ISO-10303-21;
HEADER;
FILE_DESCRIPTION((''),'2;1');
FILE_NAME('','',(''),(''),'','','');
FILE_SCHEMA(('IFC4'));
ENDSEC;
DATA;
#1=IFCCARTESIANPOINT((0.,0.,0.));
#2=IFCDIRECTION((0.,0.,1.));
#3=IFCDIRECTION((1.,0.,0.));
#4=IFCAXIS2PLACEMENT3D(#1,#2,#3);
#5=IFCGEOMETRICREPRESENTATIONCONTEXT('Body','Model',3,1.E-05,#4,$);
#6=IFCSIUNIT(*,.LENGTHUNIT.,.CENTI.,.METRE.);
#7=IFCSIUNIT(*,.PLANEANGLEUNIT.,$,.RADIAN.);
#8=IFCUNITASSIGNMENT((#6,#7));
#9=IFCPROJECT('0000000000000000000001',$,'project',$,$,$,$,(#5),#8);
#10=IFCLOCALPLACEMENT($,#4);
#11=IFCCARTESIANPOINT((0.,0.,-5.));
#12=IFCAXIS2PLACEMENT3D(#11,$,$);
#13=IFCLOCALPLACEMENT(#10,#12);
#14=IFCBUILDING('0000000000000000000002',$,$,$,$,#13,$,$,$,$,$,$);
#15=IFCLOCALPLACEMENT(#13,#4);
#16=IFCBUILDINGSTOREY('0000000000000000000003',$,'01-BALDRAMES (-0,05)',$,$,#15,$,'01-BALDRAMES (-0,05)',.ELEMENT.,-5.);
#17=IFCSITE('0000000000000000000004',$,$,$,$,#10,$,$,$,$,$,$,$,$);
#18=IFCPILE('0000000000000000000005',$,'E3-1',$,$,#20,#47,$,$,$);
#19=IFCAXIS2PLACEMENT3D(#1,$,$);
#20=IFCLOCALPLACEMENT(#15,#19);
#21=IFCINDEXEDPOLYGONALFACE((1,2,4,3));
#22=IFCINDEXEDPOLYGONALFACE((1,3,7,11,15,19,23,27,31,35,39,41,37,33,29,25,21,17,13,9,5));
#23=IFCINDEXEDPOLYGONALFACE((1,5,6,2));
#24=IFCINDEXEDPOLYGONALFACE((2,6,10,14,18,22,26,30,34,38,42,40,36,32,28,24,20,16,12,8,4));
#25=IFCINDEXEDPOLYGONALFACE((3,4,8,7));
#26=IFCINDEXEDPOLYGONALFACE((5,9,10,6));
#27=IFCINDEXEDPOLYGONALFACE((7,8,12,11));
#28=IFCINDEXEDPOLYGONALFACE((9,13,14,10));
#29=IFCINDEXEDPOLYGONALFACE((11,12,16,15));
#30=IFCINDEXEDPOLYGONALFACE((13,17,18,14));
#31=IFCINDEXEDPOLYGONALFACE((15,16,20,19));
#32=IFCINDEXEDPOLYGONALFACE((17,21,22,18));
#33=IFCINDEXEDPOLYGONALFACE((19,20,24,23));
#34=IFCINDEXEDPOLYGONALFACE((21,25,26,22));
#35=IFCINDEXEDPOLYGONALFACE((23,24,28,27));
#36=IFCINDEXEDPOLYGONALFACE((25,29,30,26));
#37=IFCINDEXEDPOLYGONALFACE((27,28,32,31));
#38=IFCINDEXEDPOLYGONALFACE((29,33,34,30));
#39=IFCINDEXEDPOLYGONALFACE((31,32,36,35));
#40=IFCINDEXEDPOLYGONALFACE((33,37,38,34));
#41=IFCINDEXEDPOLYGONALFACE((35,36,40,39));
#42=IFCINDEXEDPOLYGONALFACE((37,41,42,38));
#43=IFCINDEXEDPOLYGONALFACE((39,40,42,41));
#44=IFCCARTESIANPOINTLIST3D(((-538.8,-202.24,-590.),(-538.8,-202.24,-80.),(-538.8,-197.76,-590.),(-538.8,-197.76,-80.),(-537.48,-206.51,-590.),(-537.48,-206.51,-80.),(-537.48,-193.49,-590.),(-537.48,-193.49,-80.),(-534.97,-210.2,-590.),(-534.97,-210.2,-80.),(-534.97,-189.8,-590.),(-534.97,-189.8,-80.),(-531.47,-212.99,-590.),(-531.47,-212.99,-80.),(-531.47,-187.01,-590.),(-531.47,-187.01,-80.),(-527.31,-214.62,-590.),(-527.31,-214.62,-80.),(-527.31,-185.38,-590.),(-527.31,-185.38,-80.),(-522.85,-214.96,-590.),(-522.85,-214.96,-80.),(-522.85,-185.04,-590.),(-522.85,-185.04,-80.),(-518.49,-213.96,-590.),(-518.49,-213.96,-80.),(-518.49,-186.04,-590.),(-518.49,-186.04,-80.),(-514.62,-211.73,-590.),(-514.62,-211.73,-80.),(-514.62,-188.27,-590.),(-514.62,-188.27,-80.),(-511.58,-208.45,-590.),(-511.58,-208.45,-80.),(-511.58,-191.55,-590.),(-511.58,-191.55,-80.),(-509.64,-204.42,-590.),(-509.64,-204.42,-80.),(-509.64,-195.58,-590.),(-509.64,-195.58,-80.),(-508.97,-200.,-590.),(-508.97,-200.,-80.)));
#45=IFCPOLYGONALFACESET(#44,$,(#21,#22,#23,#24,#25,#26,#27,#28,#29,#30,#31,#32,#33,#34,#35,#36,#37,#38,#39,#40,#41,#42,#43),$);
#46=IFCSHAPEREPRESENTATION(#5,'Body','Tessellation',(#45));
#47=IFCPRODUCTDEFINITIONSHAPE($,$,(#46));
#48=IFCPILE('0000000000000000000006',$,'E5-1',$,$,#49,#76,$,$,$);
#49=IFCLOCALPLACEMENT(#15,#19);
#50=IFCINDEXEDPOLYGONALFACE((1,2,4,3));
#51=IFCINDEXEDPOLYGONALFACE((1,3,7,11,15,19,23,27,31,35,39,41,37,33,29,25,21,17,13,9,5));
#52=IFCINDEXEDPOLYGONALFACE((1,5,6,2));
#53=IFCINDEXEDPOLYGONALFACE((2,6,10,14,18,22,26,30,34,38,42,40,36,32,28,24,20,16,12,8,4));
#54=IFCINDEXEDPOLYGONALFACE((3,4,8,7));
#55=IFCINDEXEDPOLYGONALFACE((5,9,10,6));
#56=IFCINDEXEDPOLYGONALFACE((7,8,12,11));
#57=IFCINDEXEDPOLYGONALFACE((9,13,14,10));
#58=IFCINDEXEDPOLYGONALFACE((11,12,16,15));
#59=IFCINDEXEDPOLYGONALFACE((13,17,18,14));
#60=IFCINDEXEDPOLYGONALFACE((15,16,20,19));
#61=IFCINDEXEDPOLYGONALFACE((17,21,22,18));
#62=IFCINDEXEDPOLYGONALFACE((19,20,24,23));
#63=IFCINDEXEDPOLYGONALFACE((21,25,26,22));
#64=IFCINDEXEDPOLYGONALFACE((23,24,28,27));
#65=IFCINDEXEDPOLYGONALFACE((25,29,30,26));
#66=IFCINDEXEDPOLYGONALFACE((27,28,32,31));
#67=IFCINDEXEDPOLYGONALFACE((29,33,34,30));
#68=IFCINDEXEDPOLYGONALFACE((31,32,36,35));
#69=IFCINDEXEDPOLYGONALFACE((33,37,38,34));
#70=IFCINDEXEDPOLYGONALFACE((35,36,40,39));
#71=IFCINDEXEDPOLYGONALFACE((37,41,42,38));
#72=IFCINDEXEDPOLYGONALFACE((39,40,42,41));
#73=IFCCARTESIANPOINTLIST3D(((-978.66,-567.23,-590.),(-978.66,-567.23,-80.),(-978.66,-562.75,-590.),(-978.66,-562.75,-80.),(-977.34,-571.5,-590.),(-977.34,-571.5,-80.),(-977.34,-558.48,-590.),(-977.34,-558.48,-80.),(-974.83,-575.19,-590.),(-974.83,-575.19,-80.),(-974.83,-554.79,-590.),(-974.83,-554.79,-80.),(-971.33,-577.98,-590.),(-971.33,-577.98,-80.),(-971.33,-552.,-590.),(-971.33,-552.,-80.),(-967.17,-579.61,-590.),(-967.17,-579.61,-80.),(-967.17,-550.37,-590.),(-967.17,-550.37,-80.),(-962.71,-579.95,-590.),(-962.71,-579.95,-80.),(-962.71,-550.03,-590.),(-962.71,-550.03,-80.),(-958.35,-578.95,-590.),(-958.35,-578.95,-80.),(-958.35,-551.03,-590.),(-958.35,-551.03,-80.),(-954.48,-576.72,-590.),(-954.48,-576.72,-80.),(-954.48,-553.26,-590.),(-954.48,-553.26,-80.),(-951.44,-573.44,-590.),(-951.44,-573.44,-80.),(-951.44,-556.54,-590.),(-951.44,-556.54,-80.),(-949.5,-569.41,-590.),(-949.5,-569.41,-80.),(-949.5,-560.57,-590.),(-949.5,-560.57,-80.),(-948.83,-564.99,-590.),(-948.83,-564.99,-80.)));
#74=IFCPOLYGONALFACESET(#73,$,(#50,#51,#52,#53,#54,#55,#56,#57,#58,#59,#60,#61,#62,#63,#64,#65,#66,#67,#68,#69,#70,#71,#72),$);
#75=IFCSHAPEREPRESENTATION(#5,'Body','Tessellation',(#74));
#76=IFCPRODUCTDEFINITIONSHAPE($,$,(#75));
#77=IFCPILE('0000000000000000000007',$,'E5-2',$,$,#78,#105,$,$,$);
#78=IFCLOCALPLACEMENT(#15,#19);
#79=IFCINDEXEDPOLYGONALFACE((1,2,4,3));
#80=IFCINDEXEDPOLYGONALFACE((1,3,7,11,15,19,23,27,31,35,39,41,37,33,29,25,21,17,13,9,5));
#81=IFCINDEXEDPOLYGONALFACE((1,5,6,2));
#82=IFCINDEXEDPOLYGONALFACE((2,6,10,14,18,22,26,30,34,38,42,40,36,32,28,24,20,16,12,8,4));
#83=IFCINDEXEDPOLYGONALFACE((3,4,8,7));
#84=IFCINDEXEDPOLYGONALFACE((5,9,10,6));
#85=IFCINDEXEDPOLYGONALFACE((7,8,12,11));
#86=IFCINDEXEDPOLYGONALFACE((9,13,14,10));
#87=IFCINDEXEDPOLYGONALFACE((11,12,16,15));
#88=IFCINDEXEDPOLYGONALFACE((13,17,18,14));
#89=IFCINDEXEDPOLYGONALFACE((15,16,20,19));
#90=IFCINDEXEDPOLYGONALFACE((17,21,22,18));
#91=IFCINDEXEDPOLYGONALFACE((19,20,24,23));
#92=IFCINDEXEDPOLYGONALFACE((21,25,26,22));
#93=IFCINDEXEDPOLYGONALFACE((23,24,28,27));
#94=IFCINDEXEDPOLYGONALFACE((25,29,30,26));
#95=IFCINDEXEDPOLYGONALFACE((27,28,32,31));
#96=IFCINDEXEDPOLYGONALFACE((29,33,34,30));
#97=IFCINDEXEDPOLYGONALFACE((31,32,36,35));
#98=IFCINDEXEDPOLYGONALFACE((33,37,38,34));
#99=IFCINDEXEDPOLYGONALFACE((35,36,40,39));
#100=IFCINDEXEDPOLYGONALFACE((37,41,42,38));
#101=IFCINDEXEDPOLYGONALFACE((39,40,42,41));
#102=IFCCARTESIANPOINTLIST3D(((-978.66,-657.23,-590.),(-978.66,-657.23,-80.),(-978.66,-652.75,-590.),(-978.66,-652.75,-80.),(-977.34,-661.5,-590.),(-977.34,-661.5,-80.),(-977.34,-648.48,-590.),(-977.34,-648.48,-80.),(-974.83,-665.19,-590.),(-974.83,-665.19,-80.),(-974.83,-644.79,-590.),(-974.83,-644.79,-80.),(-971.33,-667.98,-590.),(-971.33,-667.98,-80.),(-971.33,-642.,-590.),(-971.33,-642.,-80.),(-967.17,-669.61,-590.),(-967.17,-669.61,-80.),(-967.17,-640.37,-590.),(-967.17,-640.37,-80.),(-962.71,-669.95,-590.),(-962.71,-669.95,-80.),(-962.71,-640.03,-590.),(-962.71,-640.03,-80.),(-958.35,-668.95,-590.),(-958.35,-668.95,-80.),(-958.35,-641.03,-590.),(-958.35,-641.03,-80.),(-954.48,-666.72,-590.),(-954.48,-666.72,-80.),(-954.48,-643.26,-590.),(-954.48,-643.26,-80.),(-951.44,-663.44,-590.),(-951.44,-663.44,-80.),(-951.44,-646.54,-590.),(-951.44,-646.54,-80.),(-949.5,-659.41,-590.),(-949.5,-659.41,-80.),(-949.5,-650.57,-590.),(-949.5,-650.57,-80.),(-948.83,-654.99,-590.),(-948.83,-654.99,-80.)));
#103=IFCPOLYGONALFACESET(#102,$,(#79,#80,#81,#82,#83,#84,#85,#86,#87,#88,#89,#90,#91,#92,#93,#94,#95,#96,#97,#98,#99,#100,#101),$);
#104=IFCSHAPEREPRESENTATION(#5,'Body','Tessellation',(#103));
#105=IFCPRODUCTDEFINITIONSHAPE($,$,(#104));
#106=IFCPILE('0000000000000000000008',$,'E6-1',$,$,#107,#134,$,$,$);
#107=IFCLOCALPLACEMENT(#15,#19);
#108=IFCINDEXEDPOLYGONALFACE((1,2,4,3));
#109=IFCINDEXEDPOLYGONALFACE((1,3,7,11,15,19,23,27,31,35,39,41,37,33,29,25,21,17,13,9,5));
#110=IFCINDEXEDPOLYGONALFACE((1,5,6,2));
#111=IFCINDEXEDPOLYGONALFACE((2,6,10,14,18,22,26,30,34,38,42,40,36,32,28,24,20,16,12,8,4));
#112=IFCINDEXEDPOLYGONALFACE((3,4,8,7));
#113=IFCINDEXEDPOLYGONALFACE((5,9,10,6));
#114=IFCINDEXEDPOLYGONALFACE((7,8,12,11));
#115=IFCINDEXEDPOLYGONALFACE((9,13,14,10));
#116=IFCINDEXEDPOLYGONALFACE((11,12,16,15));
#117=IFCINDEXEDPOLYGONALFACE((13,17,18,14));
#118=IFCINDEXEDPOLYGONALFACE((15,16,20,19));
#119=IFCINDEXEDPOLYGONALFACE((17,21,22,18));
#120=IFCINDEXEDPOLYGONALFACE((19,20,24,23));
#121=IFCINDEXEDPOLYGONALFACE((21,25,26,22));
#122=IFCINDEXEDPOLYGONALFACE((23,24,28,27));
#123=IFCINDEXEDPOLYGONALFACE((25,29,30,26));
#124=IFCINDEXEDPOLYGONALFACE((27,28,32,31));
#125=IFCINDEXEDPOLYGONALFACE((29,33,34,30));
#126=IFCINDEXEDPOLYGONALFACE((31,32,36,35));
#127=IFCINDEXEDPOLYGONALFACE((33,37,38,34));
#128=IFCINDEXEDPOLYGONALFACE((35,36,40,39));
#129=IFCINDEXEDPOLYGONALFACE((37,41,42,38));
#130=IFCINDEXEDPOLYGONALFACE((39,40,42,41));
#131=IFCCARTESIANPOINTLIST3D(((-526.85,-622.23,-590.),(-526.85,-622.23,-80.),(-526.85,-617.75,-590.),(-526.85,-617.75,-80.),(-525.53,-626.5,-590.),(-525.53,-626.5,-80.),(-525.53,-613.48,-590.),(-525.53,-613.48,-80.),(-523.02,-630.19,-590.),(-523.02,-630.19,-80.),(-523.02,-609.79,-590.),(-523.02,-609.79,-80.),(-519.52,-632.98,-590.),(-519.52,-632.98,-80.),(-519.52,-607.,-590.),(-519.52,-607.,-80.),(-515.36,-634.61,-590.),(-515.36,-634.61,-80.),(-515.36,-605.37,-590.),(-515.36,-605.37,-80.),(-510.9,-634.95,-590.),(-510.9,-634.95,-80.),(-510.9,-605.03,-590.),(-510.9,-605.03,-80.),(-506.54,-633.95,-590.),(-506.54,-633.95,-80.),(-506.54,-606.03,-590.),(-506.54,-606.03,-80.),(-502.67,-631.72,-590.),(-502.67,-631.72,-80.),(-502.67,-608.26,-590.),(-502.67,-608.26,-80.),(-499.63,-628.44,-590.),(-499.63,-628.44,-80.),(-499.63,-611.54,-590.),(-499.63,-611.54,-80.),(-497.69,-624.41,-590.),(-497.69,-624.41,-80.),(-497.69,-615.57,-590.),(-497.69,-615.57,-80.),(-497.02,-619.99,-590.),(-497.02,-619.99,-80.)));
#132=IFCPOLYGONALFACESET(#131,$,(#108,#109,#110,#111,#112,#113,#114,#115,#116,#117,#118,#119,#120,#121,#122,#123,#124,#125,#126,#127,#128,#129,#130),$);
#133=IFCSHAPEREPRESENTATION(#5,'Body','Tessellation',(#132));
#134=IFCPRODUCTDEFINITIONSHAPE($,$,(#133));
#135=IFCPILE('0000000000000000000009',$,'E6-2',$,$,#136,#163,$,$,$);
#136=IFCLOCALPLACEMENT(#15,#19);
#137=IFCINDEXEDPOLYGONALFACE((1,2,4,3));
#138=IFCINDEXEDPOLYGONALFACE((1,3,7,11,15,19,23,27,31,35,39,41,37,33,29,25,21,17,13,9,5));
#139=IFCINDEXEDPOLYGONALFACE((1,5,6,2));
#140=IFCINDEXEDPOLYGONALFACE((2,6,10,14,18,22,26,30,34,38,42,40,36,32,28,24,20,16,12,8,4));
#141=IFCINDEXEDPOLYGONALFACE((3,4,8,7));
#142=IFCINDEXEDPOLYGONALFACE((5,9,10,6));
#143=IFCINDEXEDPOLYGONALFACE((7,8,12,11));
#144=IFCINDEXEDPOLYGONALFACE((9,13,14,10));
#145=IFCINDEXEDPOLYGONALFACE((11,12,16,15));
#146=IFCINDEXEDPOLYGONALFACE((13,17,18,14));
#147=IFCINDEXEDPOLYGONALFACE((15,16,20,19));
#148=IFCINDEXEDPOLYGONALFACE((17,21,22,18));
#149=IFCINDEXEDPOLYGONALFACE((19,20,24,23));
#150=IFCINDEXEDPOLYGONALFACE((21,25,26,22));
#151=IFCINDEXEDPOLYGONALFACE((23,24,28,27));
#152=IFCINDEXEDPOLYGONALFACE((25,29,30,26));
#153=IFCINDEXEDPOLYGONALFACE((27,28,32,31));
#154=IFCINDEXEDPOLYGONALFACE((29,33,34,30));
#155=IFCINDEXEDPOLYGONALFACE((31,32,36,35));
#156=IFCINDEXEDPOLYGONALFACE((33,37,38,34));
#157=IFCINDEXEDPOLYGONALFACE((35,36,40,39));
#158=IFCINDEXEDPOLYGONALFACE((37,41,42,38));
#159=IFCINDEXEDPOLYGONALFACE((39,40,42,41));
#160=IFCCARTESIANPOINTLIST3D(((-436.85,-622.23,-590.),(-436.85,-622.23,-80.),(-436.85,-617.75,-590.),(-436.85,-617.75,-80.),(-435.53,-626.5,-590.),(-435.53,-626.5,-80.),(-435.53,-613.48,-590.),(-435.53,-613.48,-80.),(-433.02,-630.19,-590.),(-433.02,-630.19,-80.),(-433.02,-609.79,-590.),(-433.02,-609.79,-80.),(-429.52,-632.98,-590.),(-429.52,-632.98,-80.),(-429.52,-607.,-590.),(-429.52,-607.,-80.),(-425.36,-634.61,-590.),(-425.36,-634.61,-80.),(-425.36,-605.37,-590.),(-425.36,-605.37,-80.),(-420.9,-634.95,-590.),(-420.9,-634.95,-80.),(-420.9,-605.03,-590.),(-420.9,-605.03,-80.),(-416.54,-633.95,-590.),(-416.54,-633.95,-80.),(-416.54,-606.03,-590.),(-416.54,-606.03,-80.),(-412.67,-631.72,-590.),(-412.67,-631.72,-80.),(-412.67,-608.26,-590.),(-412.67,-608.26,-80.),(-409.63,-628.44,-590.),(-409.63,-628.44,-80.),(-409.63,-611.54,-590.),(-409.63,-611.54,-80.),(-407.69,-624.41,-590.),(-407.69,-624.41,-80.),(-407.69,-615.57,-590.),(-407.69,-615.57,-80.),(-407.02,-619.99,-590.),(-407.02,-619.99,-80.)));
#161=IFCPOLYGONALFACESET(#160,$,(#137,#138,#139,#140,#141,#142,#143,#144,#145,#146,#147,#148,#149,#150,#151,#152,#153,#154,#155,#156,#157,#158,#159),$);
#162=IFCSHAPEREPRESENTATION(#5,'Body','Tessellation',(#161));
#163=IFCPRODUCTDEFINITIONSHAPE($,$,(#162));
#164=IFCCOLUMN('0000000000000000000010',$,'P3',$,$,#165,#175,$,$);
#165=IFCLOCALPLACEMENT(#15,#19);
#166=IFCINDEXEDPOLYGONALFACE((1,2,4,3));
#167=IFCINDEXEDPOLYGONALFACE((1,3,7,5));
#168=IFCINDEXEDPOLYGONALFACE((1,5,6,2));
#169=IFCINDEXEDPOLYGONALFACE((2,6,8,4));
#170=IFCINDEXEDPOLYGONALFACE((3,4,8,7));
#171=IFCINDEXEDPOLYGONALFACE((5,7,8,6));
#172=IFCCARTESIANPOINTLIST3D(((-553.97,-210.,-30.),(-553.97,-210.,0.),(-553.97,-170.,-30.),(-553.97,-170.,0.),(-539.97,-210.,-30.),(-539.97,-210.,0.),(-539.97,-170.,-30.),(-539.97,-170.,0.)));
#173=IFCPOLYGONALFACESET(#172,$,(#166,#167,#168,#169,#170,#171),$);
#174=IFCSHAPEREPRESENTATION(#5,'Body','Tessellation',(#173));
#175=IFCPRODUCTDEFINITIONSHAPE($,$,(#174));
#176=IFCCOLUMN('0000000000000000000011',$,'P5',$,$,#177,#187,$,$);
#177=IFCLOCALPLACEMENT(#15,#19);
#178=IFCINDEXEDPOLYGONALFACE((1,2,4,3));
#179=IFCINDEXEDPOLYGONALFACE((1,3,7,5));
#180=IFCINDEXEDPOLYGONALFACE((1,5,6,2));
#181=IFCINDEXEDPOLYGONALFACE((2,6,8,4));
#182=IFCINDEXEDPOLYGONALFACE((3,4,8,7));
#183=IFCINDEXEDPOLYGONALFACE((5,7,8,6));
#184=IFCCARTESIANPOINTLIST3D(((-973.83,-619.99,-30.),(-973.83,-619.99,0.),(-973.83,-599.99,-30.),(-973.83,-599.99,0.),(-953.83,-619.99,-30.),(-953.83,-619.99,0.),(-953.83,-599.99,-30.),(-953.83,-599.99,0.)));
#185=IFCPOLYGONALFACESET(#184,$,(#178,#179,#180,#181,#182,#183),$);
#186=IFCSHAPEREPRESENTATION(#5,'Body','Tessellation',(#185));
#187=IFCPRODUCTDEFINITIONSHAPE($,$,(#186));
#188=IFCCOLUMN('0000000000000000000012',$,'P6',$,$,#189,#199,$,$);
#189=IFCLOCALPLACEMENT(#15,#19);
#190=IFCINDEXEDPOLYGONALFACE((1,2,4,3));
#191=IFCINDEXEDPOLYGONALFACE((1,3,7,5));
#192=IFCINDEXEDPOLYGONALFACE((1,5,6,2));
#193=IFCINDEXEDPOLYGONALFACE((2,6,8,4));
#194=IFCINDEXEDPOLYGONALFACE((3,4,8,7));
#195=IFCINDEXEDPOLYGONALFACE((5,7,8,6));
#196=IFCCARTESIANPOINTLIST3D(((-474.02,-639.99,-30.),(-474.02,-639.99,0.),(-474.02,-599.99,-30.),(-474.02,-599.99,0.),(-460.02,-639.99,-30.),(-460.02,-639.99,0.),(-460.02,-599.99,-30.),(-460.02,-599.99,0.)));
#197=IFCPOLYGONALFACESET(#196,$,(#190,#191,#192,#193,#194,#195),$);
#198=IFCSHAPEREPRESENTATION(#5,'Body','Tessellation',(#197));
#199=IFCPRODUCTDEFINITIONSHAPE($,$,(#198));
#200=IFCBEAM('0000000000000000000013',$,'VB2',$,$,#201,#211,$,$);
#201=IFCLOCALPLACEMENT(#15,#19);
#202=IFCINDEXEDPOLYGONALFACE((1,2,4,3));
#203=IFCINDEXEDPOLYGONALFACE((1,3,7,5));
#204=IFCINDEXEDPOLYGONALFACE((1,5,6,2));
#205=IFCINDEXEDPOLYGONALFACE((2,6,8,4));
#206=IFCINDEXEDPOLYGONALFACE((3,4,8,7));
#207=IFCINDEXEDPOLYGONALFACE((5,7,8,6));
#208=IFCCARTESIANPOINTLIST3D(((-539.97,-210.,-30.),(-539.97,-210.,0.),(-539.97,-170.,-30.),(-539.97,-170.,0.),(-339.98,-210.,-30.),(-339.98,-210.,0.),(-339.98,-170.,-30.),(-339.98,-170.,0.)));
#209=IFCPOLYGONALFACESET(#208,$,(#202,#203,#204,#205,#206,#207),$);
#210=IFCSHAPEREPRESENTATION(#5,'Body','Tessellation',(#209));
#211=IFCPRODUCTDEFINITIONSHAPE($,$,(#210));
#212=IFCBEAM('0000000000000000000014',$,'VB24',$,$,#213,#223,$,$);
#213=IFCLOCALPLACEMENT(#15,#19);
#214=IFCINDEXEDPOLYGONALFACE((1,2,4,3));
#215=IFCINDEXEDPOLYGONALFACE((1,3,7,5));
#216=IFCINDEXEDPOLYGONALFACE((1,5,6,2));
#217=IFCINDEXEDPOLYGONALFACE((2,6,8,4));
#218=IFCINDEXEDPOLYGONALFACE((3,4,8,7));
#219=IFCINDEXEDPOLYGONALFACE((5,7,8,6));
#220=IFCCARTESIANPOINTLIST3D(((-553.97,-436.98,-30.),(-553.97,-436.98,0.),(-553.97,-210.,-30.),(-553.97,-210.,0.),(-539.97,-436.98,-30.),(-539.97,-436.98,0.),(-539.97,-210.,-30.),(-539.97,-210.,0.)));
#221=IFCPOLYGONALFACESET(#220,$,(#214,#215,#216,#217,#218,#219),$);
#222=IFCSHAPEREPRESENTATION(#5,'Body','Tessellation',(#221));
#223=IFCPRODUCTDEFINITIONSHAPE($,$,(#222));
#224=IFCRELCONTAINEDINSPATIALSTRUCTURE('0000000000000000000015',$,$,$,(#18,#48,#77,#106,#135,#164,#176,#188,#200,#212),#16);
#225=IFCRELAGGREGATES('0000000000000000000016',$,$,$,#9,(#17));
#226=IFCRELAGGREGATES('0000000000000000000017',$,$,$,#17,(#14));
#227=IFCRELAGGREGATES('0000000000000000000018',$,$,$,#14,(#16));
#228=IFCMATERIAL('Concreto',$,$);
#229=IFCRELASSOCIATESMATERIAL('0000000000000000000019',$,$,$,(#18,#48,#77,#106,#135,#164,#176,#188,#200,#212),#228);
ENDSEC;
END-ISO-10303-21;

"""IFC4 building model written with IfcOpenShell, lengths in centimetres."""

from ifc_helpers import new_model, si_unit, frame, origin_with_axes, origin_2d_with_axis, place, context, project, spatial, rectangle, circle, extrude, material, element, save


model = new_model("IFC4")

# Units and contexts
model_context = context("Model", 3, precision=1e-05, world=origin_with_axes(), identifier="Body")
ifc_project = project(units=[si_unit("LENGTHUNIT", "METRE", prefix="CENTI"), si_unit("PLANEANGLEUNIT", "RADIAN")], contexts=[model_context])

# Site, building, storey
site_placement = place(None, origin_with_axes())
site = spatial("IfcSite", under=ifc_project, at=site_placement)
building_placement = place(site_placement, frame((0.0, 0.0, -5.0)))
building = spatial("IfcBuilding", under=site, at=building_placement)
storey_placement = place(building_placement, origin_with_axes())
storey = spatial("IfcBuildingStorey", under=building, at=storey_placement, Name="01-BALDRAMES (-0,05)", LongName="01-BALDRAMES (-0,05)", CompositionType="ELEMENT", Elevation=-5.0)

# Piles
ifc_material = material(Name="Concreto")
for number, where, z_axis, x_axis, name in (
    (1, (-523.97, -200.0, -80.0), (0.0, 0.0, 1.0), (1.0, 0.0, 0.0), "E3-1"),
    (2, (-963.83, -564.99, -80.0), (0.0, 0.0, 1.0), (1.0, 0.0, 0.0), "E5-1"),
    (3, (-963.83, -654.99, -80.0), (0.0, 0.0, 1.0), (1.0, 0.0, 0.0), "E5-2"),
    (4, (-512.02, -619.99, -80.0), (0.0, 0.0, 1.0), (1.0, 0.0, 0.0), "E6-1"),
    (5, (-422.02, -619.99, -80.0), (0.0, 0.0, 1.0), (1.0, 0.0, 0.0), "E6-2"),
):
    element("IfcPile", number, at=place(storey_placement, frame(where, z_axis=z_axis, x_axis=x_axis)), inside=storey, material=ifc_material, Name=name, context=model_context, shape_type="SweptSolid", body=[
        extrude(circle(Radius=15.0, at=origin_2d_with_axis()), frame((0.0, 0.0, -510.0), z_axis=(0.0, 0.0, 1.0), x_axis=(1.0, 0.0, 0.0)), (0.0, 0.0, 1.0), 510.0),
    ])

# Columns
column_1_placement = place(storey_placement, frame((-546.97, -190.0, 0.0), z_axis=(0.0, 0.0, 1.0), x_axis=(1.0, 0.0, 0.0)))
element("IfcColumn", 6, at=column_1_placement, inside=storey, material=ifc_material, Name="P3", context=model_context, shape_type="SolidModel", body=[
    extrude(rectangle(XDim=14.0, YDim=40.0, at=origin_2d_with_axis()), origin_with_axes(), (0.0, 0.0, -1.0), 30.0),
])
column_2_placement = place(storey_placement, frame((-963.83, -609.99, 0.0), z_axis=(0.0, 0.0, 1.0), x_axis=(1.0, 0.0, 0.0)))
element("IfcColumn", 7, at=column_2_placement, inside=storey, material=ifc_material, Name="P5", context=model_context, shape_type="SolidModel", body=[
    extrude(rectangle(XDim=20.0, YDim=20.0, at=origin_2d_with_axis()), origin_with_axes(), (0.0, 0.0, -1.0), 30.0),
])
column_3_placement = place(storey_placement, frame((-467.02, -619.99, 0.0), z_axis=(0.0, 0.0, 1.0), x_axis=(1.0, 0.0, 0.0)))
element("IfcColumn", 8, at=column_3_placement, inside=storey, material=ifc_material, Name="P6", context=model_context, shape_type="SolidModel", body=[
    extrude(rectangle(XDim=14.0, YDim=40.0, at=origin_2d_with_axis()), origin_with_axes(), (0.0, 0.0, -1.0), 30.0),
])

# Beams
beam_1_placement = place(storey_placement, frame((-439.98, -190.0, 0.0), z_axis=(0.0, 0.0, 1.0), x_axis=(1.0, 0.0, 0.0)))
element("IfcBeam", 9, at=beam_1_placement, inside=storey, material=ifc_material, Name="VB2", context=model_context, shape_type="SolidModel", body=[
    extrude(rectangle(XDim=40.0, YDim=30.0, at=origin_2d_with_axis()), frame((-100.0, 0.0, -15.0), z_axis=(1.0, 0.0, 0.0), x_axis=(0.0, -1.0, 0.0)), (0.0, 0.0, 1.0), 199.99),
])
beam_2_placement = place(storey_placement, frame((-546.97, -323.49, 0.0), z_axis=(0.0, 0.0, 1.0), x_axis=(1.0, 0.0, 0.0)))
element("IfcBeam", 10, at=beam_2_placement, inside=storey, material=ifc_material, Name="VB24", context=model_context, shape_type="SolidModel", body=[
    extrude(rectangle(XDim=14.0, YDim=30.0, at=origin_2d_with_axis()), frame((0.0, -113.49, -15.0), z_axis=(0.0, 1.0, 0.0), x_axis=(-1.0, 0.0, 0.0)), (0.0, 0.0, 1.0), 226.98),
])

save(model, "model.ifc")
